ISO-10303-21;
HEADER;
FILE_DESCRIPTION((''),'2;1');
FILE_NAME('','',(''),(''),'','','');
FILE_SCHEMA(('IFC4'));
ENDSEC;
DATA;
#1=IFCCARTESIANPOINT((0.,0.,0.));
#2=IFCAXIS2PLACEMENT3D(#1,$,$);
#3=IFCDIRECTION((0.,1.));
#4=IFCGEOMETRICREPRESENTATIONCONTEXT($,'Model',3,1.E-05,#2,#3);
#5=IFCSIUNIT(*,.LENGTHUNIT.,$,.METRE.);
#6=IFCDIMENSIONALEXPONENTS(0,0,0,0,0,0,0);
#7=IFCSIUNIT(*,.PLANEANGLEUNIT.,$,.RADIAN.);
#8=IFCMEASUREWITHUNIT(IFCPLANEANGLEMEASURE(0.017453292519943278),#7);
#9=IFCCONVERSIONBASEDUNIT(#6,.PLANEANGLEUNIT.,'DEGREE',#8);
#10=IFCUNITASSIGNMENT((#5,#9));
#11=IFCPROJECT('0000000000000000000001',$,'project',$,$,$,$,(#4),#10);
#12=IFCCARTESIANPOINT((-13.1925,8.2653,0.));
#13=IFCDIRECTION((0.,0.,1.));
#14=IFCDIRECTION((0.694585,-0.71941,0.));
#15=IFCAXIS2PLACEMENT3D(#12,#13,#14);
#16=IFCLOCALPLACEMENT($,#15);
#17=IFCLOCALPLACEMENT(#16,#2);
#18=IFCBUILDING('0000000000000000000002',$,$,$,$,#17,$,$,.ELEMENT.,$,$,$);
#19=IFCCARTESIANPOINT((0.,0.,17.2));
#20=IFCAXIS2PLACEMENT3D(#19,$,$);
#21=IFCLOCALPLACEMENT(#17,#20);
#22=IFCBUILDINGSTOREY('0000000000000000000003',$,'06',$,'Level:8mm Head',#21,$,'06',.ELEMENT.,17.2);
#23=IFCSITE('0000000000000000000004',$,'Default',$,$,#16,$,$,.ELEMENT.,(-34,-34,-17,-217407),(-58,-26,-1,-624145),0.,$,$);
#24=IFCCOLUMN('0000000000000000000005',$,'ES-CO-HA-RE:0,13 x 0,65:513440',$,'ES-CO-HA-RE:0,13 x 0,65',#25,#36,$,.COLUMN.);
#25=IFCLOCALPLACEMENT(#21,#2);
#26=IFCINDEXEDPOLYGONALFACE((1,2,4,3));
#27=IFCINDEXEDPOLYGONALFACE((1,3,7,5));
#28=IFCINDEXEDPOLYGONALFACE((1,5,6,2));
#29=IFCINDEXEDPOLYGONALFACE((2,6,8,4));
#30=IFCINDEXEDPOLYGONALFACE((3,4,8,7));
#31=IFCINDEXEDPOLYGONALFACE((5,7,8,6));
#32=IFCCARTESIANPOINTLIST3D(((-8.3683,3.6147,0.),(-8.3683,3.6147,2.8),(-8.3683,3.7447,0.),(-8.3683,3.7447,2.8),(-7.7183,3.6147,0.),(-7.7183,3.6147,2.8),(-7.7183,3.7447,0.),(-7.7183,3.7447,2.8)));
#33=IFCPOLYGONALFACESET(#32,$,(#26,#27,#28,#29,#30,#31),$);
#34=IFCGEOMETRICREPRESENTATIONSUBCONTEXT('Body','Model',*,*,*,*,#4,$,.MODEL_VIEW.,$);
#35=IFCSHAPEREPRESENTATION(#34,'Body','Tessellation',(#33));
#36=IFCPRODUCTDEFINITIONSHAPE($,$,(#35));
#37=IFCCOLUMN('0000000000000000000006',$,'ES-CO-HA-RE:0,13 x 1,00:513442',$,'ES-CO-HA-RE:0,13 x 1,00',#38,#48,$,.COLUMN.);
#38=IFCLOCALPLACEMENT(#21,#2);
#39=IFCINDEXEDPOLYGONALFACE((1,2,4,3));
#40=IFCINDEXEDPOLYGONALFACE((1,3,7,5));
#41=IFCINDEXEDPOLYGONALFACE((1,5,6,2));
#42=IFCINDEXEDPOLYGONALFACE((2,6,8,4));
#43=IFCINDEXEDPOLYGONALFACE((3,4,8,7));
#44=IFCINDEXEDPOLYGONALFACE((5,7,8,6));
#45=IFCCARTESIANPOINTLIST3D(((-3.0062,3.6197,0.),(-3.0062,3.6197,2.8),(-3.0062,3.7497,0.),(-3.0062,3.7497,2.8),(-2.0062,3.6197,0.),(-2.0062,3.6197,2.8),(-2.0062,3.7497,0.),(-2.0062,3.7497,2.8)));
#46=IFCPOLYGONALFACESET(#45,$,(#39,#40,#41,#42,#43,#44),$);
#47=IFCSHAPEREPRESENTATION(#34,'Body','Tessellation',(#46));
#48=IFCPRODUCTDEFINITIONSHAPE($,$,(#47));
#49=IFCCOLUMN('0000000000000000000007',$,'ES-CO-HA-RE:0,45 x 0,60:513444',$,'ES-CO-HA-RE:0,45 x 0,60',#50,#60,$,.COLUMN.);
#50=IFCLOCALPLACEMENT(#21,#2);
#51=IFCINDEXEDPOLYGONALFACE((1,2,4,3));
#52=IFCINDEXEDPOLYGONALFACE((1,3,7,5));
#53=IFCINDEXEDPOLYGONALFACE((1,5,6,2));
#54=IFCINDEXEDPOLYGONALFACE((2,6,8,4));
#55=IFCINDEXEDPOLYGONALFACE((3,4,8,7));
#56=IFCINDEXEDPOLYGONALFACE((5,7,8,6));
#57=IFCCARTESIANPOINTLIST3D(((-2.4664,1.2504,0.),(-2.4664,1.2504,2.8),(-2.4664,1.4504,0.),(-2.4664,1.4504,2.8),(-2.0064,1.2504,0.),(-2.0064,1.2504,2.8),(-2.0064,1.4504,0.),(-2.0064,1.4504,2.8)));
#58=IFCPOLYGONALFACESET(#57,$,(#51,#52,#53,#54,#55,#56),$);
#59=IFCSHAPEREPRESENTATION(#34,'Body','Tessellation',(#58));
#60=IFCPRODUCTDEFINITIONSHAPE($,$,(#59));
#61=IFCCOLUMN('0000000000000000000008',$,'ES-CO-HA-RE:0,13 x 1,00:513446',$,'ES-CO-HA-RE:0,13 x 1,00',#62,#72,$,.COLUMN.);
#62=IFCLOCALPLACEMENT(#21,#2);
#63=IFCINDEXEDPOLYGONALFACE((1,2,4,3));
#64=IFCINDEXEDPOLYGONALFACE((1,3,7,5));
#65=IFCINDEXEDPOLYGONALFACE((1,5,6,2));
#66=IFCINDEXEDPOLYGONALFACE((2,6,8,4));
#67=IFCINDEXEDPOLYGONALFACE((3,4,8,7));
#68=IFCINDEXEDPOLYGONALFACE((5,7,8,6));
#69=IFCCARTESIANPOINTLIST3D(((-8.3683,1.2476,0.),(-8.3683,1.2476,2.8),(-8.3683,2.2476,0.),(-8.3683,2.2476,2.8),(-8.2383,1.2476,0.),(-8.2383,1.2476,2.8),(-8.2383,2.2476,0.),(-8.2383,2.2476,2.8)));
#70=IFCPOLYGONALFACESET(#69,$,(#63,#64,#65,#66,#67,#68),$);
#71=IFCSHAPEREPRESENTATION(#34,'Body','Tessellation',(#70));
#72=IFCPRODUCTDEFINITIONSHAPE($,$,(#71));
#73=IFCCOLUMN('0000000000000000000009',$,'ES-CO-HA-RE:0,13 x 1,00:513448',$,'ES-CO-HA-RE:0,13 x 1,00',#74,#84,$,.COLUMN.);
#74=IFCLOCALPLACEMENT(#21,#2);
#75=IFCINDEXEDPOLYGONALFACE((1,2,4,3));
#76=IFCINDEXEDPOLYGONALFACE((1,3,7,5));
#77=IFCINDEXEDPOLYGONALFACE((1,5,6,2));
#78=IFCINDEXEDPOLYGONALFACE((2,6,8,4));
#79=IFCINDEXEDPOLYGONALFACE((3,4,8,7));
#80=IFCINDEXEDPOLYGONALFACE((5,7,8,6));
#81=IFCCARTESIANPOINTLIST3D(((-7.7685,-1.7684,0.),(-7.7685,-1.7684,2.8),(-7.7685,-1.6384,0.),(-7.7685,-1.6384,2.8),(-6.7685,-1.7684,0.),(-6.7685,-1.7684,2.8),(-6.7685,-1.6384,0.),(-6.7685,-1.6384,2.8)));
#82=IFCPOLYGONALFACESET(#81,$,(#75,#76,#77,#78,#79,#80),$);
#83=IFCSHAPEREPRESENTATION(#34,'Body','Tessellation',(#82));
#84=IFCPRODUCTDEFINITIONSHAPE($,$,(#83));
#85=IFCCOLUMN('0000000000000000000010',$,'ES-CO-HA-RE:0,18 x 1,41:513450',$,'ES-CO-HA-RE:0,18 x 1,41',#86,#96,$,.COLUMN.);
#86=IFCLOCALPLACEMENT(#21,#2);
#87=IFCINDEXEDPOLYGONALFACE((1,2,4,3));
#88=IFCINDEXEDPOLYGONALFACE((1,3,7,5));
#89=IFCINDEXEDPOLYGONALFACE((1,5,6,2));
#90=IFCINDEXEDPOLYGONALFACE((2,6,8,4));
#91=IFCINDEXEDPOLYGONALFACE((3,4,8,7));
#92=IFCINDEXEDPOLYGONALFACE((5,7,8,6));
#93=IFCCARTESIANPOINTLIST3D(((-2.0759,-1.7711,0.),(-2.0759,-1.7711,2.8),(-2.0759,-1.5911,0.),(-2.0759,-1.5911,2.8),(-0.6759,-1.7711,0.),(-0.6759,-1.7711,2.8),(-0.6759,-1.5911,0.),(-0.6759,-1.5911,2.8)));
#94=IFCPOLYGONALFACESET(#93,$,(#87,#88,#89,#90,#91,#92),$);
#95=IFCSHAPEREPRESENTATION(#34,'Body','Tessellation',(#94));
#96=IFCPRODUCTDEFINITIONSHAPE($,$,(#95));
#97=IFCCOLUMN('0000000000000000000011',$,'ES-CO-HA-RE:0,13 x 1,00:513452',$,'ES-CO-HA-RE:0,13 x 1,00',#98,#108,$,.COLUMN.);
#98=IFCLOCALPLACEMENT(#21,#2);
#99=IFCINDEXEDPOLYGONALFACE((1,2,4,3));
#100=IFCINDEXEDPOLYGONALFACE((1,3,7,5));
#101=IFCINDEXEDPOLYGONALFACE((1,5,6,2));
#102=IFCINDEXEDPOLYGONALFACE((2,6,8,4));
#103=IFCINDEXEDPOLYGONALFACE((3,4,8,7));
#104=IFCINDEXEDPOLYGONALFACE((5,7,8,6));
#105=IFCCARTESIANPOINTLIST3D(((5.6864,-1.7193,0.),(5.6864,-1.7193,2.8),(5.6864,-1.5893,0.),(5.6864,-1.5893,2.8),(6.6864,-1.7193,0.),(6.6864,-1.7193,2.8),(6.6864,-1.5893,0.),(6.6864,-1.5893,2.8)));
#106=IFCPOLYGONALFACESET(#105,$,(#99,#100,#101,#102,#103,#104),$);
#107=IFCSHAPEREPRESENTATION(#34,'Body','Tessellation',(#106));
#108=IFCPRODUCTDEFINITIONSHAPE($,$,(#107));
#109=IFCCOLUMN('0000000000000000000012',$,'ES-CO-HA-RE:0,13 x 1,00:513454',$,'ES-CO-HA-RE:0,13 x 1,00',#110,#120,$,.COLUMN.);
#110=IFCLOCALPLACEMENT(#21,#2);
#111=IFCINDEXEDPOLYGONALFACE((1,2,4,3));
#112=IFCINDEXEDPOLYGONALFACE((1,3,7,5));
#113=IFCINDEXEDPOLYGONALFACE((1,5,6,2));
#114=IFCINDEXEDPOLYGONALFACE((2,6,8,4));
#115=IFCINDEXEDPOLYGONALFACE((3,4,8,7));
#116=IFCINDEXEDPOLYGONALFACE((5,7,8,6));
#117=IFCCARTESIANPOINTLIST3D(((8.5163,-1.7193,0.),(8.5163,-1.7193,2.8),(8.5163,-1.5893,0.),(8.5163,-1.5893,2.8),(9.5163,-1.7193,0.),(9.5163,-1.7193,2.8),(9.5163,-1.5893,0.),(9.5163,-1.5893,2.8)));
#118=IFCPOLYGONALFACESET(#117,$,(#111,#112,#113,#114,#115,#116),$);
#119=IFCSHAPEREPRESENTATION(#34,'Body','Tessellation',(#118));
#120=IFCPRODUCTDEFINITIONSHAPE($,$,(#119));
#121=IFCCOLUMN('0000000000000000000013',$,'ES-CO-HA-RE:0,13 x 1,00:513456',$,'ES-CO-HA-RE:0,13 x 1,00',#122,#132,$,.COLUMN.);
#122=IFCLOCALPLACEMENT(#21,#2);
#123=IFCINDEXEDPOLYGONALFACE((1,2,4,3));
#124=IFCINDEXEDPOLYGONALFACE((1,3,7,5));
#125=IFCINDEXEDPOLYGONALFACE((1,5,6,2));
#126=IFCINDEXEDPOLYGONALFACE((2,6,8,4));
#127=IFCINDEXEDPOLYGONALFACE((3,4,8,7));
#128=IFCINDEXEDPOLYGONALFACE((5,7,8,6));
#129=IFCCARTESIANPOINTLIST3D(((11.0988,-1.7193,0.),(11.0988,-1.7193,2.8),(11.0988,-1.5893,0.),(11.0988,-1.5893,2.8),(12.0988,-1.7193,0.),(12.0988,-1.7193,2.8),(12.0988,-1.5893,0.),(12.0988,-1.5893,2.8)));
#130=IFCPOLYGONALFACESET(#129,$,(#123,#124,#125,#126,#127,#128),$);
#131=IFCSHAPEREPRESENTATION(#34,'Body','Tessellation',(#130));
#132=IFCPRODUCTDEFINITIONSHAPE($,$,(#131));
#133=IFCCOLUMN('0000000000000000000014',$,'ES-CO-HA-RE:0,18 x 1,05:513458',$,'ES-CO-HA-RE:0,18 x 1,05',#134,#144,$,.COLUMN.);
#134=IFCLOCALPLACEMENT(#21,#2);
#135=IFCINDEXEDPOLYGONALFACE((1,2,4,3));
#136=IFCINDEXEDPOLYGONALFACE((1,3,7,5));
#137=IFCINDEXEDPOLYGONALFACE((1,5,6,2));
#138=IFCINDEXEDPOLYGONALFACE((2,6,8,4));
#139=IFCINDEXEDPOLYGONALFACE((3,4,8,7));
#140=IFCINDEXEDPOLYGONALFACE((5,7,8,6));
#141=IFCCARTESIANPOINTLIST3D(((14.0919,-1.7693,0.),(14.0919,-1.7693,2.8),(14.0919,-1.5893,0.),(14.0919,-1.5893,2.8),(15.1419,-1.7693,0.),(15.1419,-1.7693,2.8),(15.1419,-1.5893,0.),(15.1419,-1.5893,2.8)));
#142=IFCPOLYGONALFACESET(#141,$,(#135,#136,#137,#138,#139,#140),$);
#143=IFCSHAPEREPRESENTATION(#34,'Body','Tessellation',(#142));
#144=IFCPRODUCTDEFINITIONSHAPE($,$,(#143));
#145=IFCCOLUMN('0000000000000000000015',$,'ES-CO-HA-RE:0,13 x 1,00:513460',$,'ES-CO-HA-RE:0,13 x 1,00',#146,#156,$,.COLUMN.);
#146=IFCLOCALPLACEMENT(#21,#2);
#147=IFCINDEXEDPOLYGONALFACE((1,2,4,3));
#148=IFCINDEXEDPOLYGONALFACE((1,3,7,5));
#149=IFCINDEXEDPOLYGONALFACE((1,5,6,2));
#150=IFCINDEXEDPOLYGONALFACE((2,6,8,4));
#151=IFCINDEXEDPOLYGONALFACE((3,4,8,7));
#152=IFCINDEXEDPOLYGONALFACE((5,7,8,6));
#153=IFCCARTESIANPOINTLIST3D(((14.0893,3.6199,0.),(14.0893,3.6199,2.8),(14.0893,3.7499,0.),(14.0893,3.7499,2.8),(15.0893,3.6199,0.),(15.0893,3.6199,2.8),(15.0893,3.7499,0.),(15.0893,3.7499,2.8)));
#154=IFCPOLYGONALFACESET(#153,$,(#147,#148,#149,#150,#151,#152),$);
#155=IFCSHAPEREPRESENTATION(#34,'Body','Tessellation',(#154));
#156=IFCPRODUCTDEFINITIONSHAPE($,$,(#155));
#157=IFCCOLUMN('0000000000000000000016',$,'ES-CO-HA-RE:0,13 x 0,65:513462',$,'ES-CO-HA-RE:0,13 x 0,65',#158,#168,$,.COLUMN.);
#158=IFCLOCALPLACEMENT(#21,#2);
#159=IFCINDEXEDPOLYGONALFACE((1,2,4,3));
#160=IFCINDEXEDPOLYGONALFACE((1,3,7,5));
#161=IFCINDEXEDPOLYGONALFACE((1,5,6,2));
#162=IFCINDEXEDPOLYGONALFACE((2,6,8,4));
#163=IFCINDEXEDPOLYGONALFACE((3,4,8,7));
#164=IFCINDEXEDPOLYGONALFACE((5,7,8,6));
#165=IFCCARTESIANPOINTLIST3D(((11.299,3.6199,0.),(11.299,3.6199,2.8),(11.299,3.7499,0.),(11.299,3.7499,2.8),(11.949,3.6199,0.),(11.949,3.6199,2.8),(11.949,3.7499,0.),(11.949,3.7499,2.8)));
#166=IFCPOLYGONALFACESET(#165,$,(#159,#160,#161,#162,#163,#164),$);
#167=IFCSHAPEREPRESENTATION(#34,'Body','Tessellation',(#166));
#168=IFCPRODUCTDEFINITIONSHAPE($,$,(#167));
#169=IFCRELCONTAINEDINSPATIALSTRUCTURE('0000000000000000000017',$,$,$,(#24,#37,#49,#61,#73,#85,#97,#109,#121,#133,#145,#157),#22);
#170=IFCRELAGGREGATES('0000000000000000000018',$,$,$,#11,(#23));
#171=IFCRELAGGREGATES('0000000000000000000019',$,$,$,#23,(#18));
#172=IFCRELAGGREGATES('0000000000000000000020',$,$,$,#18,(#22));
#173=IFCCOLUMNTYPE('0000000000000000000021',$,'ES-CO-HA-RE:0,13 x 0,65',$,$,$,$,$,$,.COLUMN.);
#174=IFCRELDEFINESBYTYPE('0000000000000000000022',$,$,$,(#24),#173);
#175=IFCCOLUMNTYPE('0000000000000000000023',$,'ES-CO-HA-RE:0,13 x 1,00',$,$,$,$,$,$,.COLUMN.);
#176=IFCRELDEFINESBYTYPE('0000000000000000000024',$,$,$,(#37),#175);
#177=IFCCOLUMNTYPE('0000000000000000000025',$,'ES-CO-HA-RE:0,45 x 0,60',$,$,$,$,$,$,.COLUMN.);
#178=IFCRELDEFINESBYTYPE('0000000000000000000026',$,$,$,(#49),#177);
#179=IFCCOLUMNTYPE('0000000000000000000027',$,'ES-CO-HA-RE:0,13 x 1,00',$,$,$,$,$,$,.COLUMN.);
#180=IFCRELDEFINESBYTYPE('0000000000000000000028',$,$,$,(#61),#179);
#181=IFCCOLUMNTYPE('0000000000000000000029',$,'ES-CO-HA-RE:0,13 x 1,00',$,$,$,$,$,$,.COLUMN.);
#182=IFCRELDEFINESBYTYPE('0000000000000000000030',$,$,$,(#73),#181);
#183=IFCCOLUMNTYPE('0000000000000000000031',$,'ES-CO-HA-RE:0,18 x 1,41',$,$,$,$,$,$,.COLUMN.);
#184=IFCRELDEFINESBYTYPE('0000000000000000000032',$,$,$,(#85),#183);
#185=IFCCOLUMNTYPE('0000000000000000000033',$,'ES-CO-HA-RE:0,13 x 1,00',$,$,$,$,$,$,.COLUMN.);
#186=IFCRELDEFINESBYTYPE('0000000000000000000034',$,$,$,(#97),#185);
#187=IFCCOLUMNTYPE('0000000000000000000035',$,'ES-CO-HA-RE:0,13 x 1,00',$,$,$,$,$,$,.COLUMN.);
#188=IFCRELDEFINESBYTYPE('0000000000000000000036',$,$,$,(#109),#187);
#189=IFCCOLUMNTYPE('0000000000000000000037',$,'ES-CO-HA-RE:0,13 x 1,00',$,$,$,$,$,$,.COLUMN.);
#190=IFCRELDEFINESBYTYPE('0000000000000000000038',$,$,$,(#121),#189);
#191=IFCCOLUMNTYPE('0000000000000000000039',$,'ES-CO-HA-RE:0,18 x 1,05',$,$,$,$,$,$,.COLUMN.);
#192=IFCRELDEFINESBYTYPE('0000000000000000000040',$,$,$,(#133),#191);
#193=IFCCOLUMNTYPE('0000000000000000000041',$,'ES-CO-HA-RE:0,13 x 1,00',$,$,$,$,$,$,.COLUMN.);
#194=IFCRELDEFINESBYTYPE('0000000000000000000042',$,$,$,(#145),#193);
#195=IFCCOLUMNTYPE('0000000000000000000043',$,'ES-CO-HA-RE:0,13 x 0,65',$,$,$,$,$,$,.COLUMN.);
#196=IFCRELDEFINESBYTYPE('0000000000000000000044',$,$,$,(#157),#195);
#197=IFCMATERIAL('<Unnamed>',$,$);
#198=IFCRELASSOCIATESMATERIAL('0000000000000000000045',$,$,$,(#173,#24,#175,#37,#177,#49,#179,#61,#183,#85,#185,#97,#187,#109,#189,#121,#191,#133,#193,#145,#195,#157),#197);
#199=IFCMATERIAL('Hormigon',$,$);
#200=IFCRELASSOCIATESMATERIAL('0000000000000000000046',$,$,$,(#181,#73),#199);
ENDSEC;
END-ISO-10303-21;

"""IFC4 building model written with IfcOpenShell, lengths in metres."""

from ifc_helpers import new_model, entity, si_unit, converted_unit, direction, frame, origin, place, context, subcontext, project, spatial, indexed_curve, outline, extrude, source, transform, mapped, material, type_object, type_shapes, element, save


model = new_model("IFC4")

# Units and contexts
model_context = context("Model", 3, precision=1e-05, world=origin(), true_north=direction((0.0, 1.0)))
body_context = subcontext(model_context, "Body", "Model", "MODEL_VIEW")
ifc_project = project(units=[si_unit("LENGTHUNIT", "METRE"), converted_unit("PLANEANGLEUNIT", "DEGREE", entity("IfcPlaneAngleMeasure", 0.017453292519943278), si_unit("PLANEANGLEUNIT", "RADIAN"), dimensions=[0, 0, 0, 0, 0, 0, 0])], contexts=[model_context])

# Site, building, storey
site_placement = place(None, frame((-13.1925, 8.2653, 0.0), z_axis=(0.0, 0.0, 1.0), x_axis=(0.694585, -0.71941, 0.0)))
site = spatial("IfcSite", under=ifc_project, at=site_placement, Name="Default", CompositionType="ELEMENT", RefLatitude=(-34, -34, -17, -217407), RefLongitude=(-58, -26, -1, -624145), RefElevation=0.0)
building_placement = place(site_placement, origin())
building = spatial("IfcBuilding", under=site, at=building_placement, CompositionType="ELEMENT")
storey_placement = place(building_placement, frame((0.0, 0.0, 17.2)))
storey = spatial("IfcBuildingStorey", under=building, at=storey_placement, Name="06", ObjectType="Level:8mm Head", LongName="06", CompositionType="ELEMENT", Elevation=17.2)

# Columns
ifc_material_1 = material(Name="<Unnamed>")
column_type_1 = type_object("IfcColumnType", Name="ES-CO-HA-RE:0,13 x 0,65", PredefinedType="COLUMN", material=ifc_material_1)
shared_shape_1 = source(origin(), body_context, "Body", "SweptSolid", [
    extrude(outline(indexed_curve([(-0.325, -0.065), (0.325, -0.065), (0.325, 0.065), (-0.325, 0.065), (-0.325, -0.065)], self_intersect=False)), frame((-8.0433, 3.6797, 17.2), z_axis=(0.0, 0.0, 1.0), x_axis=(-1.0, 0.0, 0.0)), (0.0, 0.0, 1.0), 2.8),
])
type_shapes(column_type_1, [shared_shape_1])
column_1_placement = place(storey_placement, frame((0.0, 0.0, -17.2)))
element("IfcColumn", 1, at=column_1_placement, inside=storey, type_object=column_type_1, material=ifc_material_1, Name="ES-CO-HA-RE:0,13 x 0,65:513440", ObjectType="ES-CO-HA-RE:0,13 x 0,65", PredefinedType="COLUMN", context=body_context, shape_type="MappedRepresentation", body=[
    mapped(shared_shape_1, transform((0.0, 0.0, 0.0), scale=1.0)),
])
column_type_2 = type_object("IfcColumnType", Name="ES-CO-HA-RE:0,13 x 1,00", PredefinedType="COLUMN", material=ifc_material_1)
shared_shape_2 = source(origin(), body_context, "Body", "SweptSolid", [
    extrude(outline(indexed_curve([(-0.5, -0.065), (0.5, -0.065), (0.5, 0.065), (-0.5, 0.065), (-0.5, -0.065)], self_intersect=False)), frame((-2.5062, 3.6847, 17.2), z_axis=(0.0, 0.0, 1.0), x_axis=(-1.0, 0.0, 0.0)), (0.0, 0.0, 1.0), 2.8),
])
type_shapes(column_type_2, [shared_shape_2])
column_2_placement = place(storey_placement, frame((0.0, 0.0, -17.2)))
element("IfcColumn", 2, at=column_2_placement, inside=storey, type_object=column_type_2, material=ifc_material_1, Name="ES-CO-HA-RE:0,13 x 1,00:513442", ObjectType="ES-CO-HA-RE:0,13 x 1,00", PredefinedType="COLUMN", context=body_context, shape_type="MappedRepresentation", body=[
    mapped(shared_shape_2, transform((0.0, 0.0, 0.0), scale=1.0)),
])
column_type_3 = type_object("IfcColumnType", Name="ES-CO-HA-RE:0,45 x 0,60", PredefinedType="COLUMN", material=ifc_material_1)
shared_shape_3 = source(origin(), body_context, "Body", "SweptSolid", [
    extrude(outline(indexed_curve([(-0.23, -0.1), (0.23, -0.1), (0.23, 0.1), (-0.23, 0.1), (-0.23, -0.1)], self_intersect=False)), frame((-2.2364, 1.3504, 17.2), z_axis=(0.0, 0.0, 1.0), x_axis=(-1.0, 0.0, 0.0)), (0.0, 0.0, 1.0), 2.8),
])
type_shapes(column_type_3, [shared_shape_3])
column_3_placement = place(storey_placement, frame((0.0, 0.0, -17.2)))
element("IfcColumn", 3, at=column_3_placement, inside=storey, type_object=column_type_3, material=ifc_material_1, Name="ES-CO-HA-RE:0,45 x 0,60:513444", ObjectType="ES-CO-HA-RE:0,45 x 0,60", PredefinedType="COLUMN", context=body_context, shape_type="MappedRepresentation", body=[
    mapped(shared_shape_3, transform((0.0, 0.0, 0.0), scale=1.0)),
])
column_type_4 = type_object("IfcColumnType", Name="ES-CO-HA-RE:0,13 x 1,00", PredefinedType="COLUMN", material=ifc_material_1)
shared_shape_4 = source(origin(), body_context, "Body", "SweptSolid", [
    extrude(outline(indexed_curve([(-0.5, -0.065), (0.5, -0.065), (0.5, 0.065), (-0.5, 0.065), (-0.5, -0.065)], self_intersect=False)), frame((-8.3033, 1.7476, 17.2), z_axis=(0.0, 0.0, 1.0), x_axis=(0.0, -1.0, 0.0)), (0.0, 0.0, 1.0), 2.8),
])
type_shapes(column_type_4, [shared_shape_4])
column_4_placement = place(storey_placement, frame((0.0, 0.0, -17.2)))
element("IfcColumn", 4, at=column_4_placement, inside=storey, type_object=column_type_4, material=ifc_material_1, Name="ES-CO-HA-RE:0,13 x 1,00:513446", ObjectType="ES-CO-HA-RE:0,13 x 1,00", PredefinedType="COLUMN", context=body_context, shape_type="MappedRepresentation", body=[
    mapped(shared_shape_4, transform((0.0, 0.0, 0.0), scale=1.0)),
])
ifc_material_2 = material(Name="Hormigon")
column_type_5 = type_object("IfcColumnType", Name="ES-CO-HA-RE:0,13 x 1,00", PredefinedType="COLUMN", material=ifc_material_2)
shared_shape_5 = source(origin(), body_context, "Body", "SweptSolid", [
    extrude(outline(indexed_curve([(-0.5, -0.065), (0.5, -0.065), (0.5, 0.065), (-0.5, 0.065), (-0.5, -0.065)], self_intersect=False)), frame((-7.2685, -1.7034, 17.2), z_axis=(0.0, 0.0, 1.0), x_axis=(-1.0, 0.0, 0.0)), (0.0, 0.0, 1.0), 2.8),
])
type_shapes(column_type_5, [shared_shape_5])
column_5_placement = place(storey_placement, frame((0.0, 0.0, -17.2)))
element("IfcColumn", 5, at=column_5_placement, inside=storey, type_object=column_type_5, material=ifc_material_2, Name="ES-CO-HA-RE:0,13 x 1,00:513448", ObjectType="ES-CO-HA-RE:0,13 x 1,00", PredefinedType="COLUMN", context=body_context, shape_type="MappedRepresentation", body=[
    mapped(shared_shape_5, transform((0.0, 0.0, 0.0), scale=1.0)),
])
column_type_6 = type_object("IfcColumnType", Name="ES-CO-HA-RE:0,18 x 1,41", PredefinedType="COLUMN", material=ifc_material_1)
shared_shape_6 = source(origin(), body_context, "Body", "SweptSolid", [
    extrude(outline(indexed_curve([(-0.7, -0.09), (0.7, -0.09), (0.7, 0.09), (-0.7, 0.09), (-0.7, -0.09)], self_intersect=False)), frame((-1.3759, -1.6811, 17.2), z_axis=(0.0, 0.0, 1.0), x_axis=(-1.0, 0.0, 0.0)), (0.0, 0.0, 1.0), 2.8),
])
type_shapes(column_type_6, [shared_shape_6])
column_6_placement = place(storey_placement, frame((0.0, 0.0, -17.2)))
element("IfcColumn", 6, at=column_6_placement, inside=storey, type_object=column_type_6, material=ifc_material_1, Name="ES-CO-HA-RE:0,18 x 1,41:513450", ObjectType="ES-CO-HA-RE:0,18 x 1,41", PredefinedType="COLUMN", context=body_context, shape_type="MappedRepresentation", body=[
    mapped(shared_shape_6, transform((0.0, 0.0, 0.0), scale=1.0)),
])
column_type_7 = type_object("IfcColumnType", Name="ES-CO-HA-RE:0,13 x 1,00", PredefinedType="COLUMN", material=ifc_material_1)
shared_shape_7 = source(origin(), body_context, "Body", "SweptSolid", [
    extrude(outline(indexed_curve([(-0.5, -0.065), (0.5, -0.065), (0.5, 0.065), (-0.5, 0.065), (-0.5, -0.065)], self_intersect=False)), frame((6.1864, -1.6543, 17.2), z_axis=(0.0, 0.0, 1.0), x_axis=(-1.0, 0.0, 0.0)), (0.0, 0.0, 1.0), 2.8),
])
type_shapes(column_type_7, [shared_shape_7])
column_7_placement = place(storey_placement, frame((0.0, 0.0, -17.2)))
element("IfcColumn", 7, at=column_7_placement, inside=storey, type_object=column_type_7, material=ifc_material_1, Name="ES-CO-HA-RE:0,13 x 1,00:513452", ObjectType="ES-CO-HA-RE:0,13 x 1,00", PredefinedType="COLUMN", context=body_context, shape_type="MappedRepresentation", body=[
    mapped(shared_shape_7, transform((0.0, 0.0, 0.0), scale=1.0)),
])
column_type_8 = type_object("IfcColumnType", Name="ES-CO-HA-RE:0,13 x 1,00", PredefinedType="COLUMN", material=ifc_material_1)
shared_shape_8 = source(origin(), body_context, "Body", "SweptSolid", [
    extrude(outline(indexed_curve([(-0.5, -0.065), (0.5, -0.065), (0.5, 0.065), (-0.5, 0.065), (-0.5, -0.065)], self_intersect=False)), frame((9.0163, -1.6543, 17.2), z_axis=(0.0, 0.0, 1.0), x_axis=(-1.0, 0.0, 0.0)), (0.0, 0.0, 1.0), 2.8),
])
type_shapes(column_type_8, [shared_shape_8])
column_8_placement = place(storey_placement, frame((0.0, 0.0, -17.2)))
element("IfcColumn", 8, at=column_8_placement, inside=storey, type_object=column_type_8, material=ifc_material_1, Name="ES-CO-HA-RE:0,13 x 1,00:513454", ObjectType="ES-CO-HA-RE:0,13 x 1,00", PredefinedType="COLUMN", context=body_context, shape_type="MappedRepresentation", body=[
    mapped(shared_shape_8, transform((0.0, 0.0, 0.0), scale=1.0)),
])
column_type_9 = type_object("IfcColumnType", Name="ES-CO-HA-RE:0,13 x 1,00", PredefinedType="COLUMN", material=ifc_material_1)
shared_shape_9 = source(origin(), body_context, "Body", "SweptSolid", [
    extrude(outline(indexed_curve([(-0.5, -0.065), (0.5, -0.065), (0.5, 0.065), (-0.5, 0.065), (-0.5, -0.065)], self_intersect=False)), frame((11.5988, -1.6543, 17.2), z_axis=(0.0, 0.0, 1.0), x_axis=(-1.0, 0.0, 0.0)), (0.0, 0.0, 1.0), 2.8),
])
type_shapes(column_type_9, [shared_shape_9])
column_9_placement = place(storey_placement, frame((0.0, 0.0, -17.2)))
element("IfcColumn", 9, at=column_9_placement, inside=storey, type_object=column_type_9, material=ifc_material_1, Name="ES-CO-HA-RE:0,13 x 1,00:513456", ObjectType="ES-CO-HA-RE:0,13 x 1,00", PredefinedType="COLUMN", context=body_context, shape_type="MappedRepresentation", body=[
    mapped(shared_shape_9, transform((0.0, 0.0, 0.0), scale=1.0)),
])
column_type_10 = type_object("IfcColumnType", Name="ES-CO-HA-RE:0,18 x 1,05", PredefinedType="COLUMN", material=ifc_material_1)
shared_shape_10 = source(origin(), body_context, "Body", "SweptSolid", [
    extrude(outline(indexed_curve([(-0.525, -0.09), (0.525, -0.09), (0.525, 0.09), (-0.525, 0.09), (-0.525, -0.09)], self_intersect=False)), frame((14.6169, -1.6793, 17.2), z_axis=(0.0, 0.0, 1.0), x_axis=(-1.0, 0.0, 0.0)), (0.0, 0.0, 1.0), 2.8),
])
type_shapes(column_type_10, [shared_shape_10])
column_10_placement = place(storey_placement, frame((0.0, 0.0, -17.2)))
element("IfcColumn", 10, at=column_10_placement, inside=storey, type_object=column_type_10, material=ifc_material_1, Name="ES-CO-HA-RE:0,18 x 1,05:513458", ObjectType="ES-CO-HA-RE:0,18 x 1,05", PredefinedType="COLUMN", context=body_context, shape_type="MappedRepresentation", body=[
    mapped(shared_shape_10, transform((0.0, 0.0, 0.0), scale=1.0)),
])
column_type_11 = type_object("IfcColumnType", Name="ES-CO-HA-RE:0,13 x 1,00", PredefinedType="COLUMN", material=ifc_material_1)
shared_shape_11 = source(origin(), body_context, "Body", "SweptSolid", [
    extrude(outline(indexed_curve([(-0.5, -0.065), (0.5, -0.065), (0.5, 0.065), (-0.5, 0.065), (-0.5, -0.065)], self_intersect=False)), frame((14.5893, 3.6849, 17.2), z_axis=(0.0, 0.0, 1.0), x_axis=(-1.0, 0.0, 0.0)), (0.0, 0.0, 1.0), 2.8),
])
type_shapes(column_type_11, [shared_shape_11])
column_11_placement = place(storey_placement, frame((0.0, 0.0, -17.2)))
element("IfcColumn", 11, at=column_11_placement, inside=storey, type_object=column_type_11, material=ifc_material_1, Name="ES-CO-HA-RE:0,13 x 1,00:513460", ObjectType="ES-CO-HA-RE:0,13 x 1,00", PredefinedType="COLUMN", context=body_context, shape_type="MappedRepresentation", body=[
    mapped(shared_shape_11, transform((0.0, 0.0, 0.0), scale=1.0)),
])
column_type_12 = type_object("IfcColumnType", Name="ES-CO-HA-RE:0,13 x 0,65", PredefinedType="COLUMN", material=ifc_material_1)
shared_shape_12 = source(origin(), body_context, "Body", "SweptSolid", [
    extrude(outline(indexed_curve([(-0.325, -0.065), (0.325, -0.065), (0.325, 0.065), (-0.325, 0.065), (-0.325, -0.065)], self_intersect=False)), frame((11.624, 3.6849, 17.2), z_axis=(0.0, 0.0, 1.0), x_axis=(-1.0, 0.0, 0.0)), (0.0, 0.0, 1.0), 2.8),
])
type_shapes(column_type_12, [shared_shape_12])
column_12_placement = place(storey_placement, frame((0.0, 0.0, -17.2)))
element("IfcColumn", 12, at=column_12_placement, inside=storey, type_object=column_type_12, material=ifc_material_1, Name="ES-CO-HA-RE:0,13 x 0,65:513462", ObjectType="ES-CO-HA-RE:0,13 x 0,65", PredefinedType="COLUMN", context=body_context, shape_type="MappedRepresentation", body=[
    mapped(shared_shape_12, transform((0.0, 0.0, 0.0), scale=1.0)),
])

save(model, "model.ifc")
